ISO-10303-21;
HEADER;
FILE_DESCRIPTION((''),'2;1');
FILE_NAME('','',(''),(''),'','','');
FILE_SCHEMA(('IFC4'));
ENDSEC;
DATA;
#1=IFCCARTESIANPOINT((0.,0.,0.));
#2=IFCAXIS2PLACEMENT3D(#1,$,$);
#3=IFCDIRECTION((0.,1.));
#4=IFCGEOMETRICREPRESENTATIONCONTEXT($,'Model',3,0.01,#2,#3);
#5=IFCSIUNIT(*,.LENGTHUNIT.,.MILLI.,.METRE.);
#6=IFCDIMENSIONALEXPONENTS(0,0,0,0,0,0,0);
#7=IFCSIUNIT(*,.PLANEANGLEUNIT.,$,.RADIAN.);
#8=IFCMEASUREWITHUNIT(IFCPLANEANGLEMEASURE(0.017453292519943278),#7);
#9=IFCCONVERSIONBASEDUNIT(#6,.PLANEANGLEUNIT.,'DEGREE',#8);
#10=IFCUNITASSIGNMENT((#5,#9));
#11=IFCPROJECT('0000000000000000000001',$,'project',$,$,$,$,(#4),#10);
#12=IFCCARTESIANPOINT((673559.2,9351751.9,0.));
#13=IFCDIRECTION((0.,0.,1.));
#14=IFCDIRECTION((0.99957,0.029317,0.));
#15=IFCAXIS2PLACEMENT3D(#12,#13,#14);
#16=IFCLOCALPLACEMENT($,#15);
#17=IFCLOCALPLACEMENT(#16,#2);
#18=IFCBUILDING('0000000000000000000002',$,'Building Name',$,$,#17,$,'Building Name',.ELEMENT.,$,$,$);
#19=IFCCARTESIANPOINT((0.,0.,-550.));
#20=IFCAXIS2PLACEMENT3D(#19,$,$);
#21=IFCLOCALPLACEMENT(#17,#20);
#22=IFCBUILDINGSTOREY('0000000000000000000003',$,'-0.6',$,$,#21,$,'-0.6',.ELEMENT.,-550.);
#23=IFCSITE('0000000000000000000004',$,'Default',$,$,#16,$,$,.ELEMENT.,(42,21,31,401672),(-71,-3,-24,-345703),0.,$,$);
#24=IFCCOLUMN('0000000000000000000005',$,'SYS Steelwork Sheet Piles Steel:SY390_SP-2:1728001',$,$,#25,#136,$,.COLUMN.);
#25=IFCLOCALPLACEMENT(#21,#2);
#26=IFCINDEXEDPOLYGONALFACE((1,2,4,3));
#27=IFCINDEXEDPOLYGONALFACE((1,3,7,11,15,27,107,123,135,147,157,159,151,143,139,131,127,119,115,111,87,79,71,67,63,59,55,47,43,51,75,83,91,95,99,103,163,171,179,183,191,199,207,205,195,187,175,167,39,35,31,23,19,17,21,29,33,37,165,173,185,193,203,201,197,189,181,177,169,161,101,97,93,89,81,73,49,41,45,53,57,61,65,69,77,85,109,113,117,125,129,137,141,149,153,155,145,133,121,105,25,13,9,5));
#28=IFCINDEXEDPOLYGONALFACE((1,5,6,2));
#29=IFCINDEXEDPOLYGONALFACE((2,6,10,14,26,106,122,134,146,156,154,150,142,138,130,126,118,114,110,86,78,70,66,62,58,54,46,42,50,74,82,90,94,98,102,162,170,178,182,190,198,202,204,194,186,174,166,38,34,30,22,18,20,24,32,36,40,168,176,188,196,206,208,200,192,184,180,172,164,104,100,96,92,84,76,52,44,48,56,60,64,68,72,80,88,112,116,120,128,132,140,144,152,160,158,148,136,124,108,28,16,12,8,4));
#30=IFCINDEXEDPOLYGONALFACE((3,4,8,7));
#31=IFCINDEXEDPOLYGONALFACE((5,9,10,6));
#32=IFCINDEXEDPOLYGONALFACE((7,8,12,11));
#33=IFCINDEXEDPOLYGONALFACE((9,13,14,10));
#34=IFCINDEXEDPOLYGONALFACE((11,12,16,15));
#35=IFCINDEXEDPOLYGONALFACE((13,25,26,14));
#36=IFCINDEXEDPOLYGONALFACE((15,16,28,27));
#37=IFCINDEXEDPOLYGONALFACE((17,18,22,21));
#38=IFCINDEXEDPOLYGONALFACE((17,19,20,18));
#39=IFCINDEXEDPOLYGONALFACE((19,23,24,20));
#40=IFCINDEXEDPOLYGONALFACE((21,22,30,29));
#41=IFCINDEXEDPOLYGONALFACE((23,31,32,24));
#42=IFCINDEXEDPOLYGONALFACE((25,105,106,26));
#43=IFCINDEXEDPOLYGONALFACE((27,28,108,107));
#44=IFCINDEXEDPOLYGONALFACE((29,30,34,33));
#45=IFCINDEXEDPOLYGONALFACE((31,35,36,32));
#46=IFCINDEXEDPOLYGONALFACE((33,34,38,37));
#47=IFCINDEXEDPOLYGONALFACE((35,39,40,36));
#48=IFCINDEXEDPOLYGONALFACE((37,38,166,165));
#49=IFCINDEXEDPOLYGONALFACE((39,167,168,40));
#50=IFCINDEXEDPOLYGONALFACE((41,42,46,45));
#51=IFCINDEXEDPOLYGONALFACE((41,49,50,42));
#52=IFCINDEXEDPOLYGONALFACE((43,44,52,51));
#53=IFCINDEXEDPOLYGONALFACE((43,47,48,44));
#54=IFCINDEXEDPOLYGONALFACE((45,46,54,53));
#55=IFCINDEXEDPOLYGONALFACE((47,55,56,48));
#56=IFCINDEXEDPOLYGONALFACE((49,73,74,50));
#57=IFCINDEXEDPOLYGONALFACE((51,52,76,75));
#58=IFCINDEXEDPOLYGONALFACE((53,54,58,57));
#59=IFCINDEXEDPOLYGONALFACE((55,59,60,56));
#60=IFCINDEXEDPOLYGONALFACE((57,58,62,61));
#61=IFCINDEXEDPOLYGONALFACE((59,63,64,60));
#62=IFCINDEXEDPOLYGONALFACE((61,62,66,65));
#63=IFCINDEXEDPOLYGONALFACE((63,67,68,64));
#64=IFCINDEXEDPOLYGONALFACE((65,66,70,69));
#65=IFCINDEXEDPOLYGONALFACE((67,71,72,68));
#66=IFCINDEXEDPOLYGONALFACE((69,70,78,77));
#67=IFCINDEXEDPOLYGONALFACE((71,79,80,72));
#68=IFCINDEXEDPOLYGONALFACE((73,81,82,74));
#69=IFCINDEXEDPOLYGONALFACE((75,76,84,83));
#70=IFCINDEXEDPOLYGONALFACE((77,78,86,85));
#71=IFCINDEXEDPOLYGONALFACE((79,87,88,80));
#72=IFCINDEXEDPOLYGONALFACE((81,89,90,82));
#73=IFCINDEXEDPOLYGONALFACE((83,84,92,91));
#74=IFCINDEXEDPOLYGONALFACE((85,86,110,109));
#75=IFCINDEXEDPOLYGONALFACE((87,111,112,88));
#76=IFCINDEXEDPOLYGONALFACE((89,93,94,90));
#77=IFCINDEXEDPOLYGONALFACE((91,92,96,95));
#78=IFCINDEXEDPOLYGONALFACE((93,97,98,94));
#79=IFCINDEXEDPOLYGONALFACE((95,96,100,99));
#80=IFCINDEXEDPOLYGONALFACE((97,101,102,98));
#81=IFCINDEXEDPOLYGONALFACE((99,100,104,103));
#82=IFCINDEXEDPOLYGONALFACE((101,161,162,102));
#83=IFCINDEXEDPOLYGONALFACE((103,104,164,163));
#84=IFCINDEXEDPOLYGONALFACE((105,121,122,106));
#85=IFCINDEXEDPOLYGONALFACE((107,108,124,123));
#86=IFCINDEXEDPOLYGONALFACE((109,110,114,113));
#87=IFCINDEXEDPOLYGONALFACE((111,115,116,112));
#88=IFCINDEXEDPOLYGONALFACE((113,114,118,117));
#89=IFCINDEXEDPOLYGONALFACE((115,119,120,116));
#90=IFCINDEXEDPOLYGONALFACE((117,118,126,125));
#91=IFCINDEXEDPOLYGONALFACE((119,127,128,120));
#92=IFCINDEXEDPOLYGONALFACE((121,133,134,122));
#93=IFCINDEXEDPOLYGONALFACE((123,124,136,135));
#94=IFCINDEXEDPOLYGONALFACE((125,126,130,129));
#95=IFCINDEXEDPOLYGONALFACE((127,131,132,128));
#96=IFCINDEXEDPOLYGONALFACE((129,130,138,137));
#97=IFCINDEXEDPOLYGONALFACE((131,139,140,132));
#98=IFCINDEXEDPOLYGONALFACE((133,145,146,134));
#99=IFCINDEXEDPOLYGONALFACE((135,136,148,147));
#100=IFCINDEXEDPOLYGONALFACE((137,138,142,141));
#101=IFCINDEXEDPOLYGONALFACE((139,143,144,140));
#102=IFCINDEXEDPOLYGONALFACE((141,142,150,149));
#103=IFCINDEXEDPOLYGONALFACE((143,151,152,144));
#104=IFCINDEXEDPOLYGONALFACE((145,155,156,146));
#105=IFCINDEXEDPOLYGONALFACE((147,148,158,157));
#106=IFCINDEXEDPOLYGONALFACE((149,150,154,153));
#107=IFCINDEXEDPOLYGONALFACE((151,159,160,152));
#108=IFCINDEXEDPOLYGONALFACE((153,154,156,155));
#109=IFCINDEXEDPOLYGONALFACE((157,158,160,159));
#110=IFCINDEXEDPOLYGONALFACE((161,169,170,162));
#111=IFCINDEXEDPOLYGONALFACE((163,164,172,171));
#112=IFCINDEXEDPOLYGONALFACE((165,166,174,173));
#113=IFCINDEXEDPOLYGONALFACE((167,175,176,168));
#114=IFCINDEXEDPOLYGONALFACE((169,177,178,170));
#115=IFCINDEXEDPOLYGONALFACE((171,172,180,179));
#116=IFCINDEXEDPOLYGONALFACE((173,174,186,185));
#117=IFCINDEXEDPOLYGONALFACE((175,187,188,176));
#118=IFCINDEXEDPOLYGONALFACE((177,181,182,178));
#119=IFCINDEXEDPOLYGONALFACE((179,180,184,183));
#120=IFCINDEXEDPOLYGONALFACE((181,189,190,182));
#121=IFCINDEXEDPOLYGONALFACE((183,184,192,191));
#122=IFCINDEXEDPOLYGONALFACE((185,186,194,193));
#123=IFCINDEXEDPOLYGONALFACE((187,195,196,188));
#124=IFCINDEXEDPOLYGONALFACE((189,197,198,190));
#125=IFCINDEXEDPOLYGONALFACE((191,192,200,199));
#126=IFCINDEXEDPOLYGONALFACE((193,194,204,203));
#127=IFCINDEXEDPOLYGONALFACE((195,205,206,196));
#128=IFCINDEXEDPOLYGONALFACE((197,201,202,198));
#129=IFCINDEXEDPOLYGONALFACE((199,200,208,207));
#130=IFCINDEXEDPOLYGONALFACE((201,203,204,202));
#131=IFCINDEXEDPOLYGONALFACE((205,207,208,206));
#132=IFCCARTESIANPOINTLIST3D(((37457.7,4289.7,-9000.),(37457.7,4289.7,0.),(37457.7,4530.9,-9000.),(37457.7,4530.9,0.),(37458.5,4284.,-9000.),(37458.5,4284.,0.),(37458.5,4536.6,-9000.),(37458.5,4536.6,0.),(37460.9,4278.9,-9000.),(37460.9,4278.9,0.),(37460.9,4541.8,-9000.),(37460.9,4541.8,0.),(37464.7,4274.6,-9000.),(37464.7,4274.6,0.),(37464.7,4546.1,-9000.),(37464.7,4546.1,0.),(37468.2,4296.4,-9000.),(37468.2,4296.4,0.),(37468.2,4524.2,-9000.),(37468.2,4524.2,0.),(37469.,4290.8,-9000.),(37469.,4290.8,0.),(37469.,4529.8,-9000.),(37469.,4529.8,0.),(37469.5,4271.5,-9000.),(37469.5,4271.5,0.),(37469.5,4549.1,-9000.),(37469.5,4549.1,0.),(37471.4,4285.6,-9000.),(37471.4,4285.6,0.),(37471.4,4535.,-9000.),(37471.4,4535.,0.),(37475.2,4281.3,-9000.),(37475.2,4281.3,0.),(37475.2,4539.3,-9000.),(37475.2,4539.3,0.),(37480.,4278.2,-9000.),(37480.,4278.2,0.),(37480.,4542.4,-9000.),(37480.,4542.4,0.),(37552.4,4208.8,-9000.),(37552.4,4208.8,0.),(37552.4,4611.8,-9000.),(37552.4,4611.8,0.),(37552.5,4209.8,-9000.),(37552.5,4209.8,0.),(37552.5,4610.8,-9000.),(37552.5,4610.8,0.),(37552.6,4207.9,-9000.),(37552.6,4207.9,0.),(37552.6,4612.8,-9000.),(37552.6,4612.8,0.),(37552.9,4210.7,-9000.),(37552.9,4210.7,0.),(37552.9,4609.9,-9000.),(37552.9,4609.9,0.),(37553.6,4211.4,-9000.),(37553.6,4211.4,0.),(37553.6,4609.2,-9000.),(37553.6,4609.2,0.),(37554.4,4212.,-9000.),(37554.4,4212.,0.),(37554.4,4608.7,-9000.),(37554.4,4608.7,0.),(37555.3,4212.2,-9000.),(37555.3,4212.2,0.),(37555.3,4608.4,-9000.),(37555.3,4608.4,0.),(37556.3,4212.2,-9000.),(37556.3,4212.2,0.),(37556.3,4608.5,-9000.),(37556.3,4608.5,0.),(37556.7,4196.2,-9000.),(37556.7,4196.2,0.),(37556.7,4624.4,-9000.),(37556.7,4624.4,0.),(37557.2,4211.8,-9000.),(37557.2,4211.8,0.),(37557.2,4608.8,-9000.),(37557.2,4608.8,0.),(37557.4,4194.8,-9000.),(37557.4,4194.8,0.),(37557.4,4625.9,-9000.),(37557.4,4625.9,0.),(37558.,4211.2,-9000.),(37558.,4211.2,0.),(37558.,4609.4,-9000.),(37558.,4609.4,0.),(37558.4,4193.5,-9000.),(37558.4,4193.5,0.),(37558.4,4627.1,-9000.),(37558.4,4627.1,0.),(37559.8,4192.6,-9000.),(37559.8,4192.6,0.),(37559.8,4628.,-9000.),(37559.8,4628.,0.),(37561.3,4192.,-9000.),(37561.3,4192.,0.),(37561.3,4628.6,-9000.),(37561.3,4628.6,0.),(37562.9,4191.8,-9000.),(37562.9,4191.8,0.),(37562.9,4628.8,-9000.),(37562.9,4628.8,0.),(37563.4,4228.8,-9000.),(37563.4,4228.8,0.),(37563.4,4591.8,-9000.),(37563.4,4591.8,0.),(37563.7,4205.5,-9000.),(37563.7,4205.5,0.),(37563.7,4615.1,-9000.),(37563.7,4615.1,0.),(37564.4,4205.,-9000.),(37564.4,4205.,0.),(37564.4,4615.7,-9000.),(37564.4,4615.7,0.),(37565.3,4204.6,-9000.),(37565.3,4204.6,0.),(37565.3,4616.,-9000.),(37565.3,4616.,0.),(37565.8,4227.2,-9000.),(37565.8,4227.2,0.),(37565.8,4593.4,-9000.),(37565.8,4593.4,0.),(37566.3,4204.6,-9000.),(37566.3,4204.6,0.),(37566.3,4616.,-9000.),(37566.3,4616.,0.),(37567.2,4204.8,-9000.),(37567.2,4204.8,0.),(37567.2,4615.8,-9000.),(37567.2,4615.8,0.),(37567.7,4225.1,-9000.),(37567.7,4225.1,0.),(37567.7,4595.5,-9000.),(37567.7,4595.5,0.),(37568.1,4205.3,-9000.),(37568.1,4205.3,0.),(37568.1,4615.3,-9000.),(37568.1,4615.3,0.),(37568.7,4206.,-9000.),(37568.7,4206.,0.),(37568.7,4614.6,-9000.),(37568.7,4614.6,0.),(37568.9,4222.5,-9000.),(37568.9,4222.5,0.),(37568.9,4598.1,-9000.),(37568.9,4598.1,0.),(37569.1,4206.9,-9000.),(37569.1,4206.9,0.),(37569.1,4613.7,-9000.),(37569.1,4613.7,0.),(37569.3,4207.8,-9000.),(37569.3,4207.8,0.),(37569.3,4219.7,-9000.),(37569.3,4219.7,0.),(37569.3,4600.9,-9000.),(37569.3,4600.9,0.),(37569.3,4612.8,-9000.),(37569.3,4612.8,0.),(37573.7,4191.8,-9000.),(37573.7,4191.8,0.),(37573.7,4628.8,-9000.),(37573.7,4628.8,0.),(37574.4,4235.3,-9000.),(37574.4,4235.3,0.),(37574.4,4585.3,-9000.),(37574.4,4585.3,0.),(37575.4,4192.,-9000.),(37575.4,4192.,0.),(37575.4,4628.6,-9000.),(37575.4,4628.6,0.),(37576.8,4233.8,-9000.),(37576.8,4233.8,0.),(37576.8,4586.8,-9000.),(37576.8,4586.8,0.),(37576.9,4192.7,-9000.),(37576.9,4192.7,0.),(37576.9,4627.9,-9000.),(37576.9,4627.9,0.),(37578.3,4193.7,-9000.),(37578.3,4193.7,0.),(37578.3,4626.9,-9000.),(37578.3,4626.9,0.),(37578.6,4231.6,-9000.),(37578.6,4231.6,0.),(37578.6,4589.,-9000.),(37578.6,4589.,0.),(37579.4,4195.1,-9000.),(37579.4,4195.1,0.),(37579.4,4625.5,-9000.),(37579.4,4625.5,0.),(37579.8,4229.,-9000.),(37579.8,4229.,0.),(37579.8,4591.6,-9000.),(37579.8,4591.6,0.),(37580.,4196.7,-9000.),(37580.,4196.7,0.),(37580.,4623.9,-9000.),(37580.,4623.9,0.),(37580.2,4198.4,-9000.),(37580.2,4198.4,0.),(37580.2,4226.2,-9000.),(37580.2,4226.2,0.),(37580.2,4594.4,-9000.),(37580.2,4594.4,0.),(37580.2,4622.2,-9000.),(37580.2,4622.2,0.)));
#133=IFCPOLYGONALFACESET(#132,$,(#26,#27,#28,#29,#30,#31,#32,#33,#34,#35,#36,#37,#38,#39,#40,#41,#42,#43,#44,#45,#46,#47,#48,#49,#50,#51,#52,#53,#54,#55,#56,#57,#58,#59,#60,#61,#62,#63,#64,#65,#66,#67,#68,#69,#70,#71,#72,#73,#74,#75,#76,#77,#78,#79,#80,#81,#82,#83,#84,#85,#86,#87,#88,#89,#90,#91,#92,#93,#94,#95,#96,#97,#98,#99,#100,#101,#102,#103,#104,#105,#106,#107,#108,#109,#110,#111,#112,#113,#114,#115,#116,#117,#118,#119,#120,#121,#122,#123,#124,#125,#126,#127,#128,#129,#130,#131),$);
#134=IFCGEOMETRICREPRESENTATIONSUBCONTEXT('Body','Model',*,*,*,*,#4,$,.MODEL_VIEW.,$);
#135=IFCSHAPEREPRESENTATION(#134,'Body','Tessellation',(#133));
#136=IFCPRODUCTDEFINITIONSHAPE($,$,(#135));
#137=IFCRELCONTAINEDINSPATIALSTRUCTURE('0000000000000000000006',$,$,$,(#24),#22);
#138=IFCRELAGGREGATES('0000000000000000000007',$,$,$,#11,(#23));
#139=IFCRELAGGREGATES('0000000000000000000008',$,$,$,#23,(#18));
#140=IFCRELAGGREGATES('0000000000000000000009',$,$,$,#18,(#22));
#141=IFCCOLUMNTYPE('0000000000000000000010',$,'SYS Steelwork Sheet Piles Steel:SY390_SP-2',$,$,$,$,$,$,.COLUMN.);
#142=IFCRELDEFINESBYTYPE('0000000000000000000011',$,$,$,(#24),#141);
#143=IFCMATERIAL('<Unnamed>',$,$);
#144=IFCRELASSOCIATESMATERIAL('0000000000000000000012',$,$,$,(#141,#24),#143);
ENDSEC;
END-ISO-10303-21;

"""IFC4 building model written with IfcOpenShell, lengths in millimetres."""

from ifc_helpers import new_model, entity, si_unit, converted_unit, direction, frame, origin, place, context, subcontext, project, spatial, line, arc, indexed_curve, outline, extrude, source, transform, mapped, material, type_object, type_shapes, element, save


model = new_model("IFC4")

# Units and contexts
model_context = context("Model", 3, precision=0.01, world=origin(), true_north=direction((0.0, 1.0)))
body_context = subcontext(model_context, "Body", "Model", "MODEL_VIEW")
ifc_project = project(units=[si_unit("LENGTHUNIT", "METRE", prefix="MILLI"), converted_unit("PLANEANGLEUNIT", "DEGREE", entity("IfcPlaneAngleMeasure", 0.017453292519943278), si_unit("PLANEANGLEUNIT", "RADIAN"), dimensions=[0, 0, 0, 0, 0, 0, 0])], contexts=[model_context])

# Site, building, storey
site_placement = place(None, frame((673559.2, 9351751.9, 0.0), z_axis=(0.0, 0.0, 1.0), x_axis=(0.99957, 0.029317, 0.0)))
site = spatial("IfcSite", under=ifc_project, at=site_placement, Name="Default", CompositionType="ELEMENT", RefLatitude=(42, 21, 31, 401672), RefLongitude=(-71, -3, -24, -345703), RefElevation=0.0)
building_placement = place(site_placement, origin())
building = spatial("IfcBuilding", under=site, at=building_placement, Name="Building Name", LongName="Building Name", CompositionType="ELEMENT")
storey_placement = place(building_placement, frame((0.0, 0.0, -550.0)))
storey = spatial("IfcBuildingStorey", under=building, at=storey_placement, Name="-0.6", LongName="-0.6", CompositionType="ELEMENT", Elevation=-550.0)

# Column
ifc_material_1 = material(Name="<Unnamed>")
column_type = type_object("IfcColumnType", Name="SYS Steelwork Sheet Piles Steel:SY390_SP-2", PredefinedType="COLUMN", material=ifc_material_1)
shared_shape = source(origin(), body_context, "Body", "SweptSolid", [
    extrude(outline(indexed_curve([(-120.6, 84.7), (-131.4, 81.6), (-138.8, 73.0), (-181.5, -20.9), (-185.2, -25.2), (-190.6, -26.8), (-202.5, -26.8), (-205.5, -24.8), (-204.8, -21.2), (-199.1, -15.5), (-198.6, -11.5), (-202.5, -10.1), (-214.1, -14.2), (-217.3, -16.6), (-218.5, -20.4), (-218.5, -31.2), (-216.6, -35.8), (-211.9, -37.8), (-184.1, -37.8), (-178.7, -36.2), (-175.0, -31.9), (-132.1, 62.5), (-124.7, 71.1), (-113.9, 74.2), (113.9, 74.2), (124.7, 71.1), (132.1, 62.5), (175.0, -31.9), (178.7, -36.2), (184.1, -37.8), (211.9, -37.8), (216.6, -35.8), (218.5, -31.2), (218.5, -20.4), (217.3, -16.6), (214.1, -14.2), (202.5, -10.1), (198.6, -11.5), (199.1, -15.5), (204.8, -21.2), (205.5, -24.8), (202.5, -26.8), (190.6, -26.8), (185.2, -25.2), (181.5, -20.9), (138.8, 73.0), (131.4, 81.6), (120.6, 84.7)], segments=[arc(1, 2, 3), line(3, 4), arc(4, 5, 6), line(6, 7), arc(7, 8, 9), line(9, 10), arc(10, 11, 12), line(12, 13), arc(13, 14, 15), line(15, 16), arc(16, 17, 18), line(18, 19), arc(19, 20, 21), line(21, 22), arc(22, 23, 24), line(24, 25), arc(25, 26, 27), line(27, 28), arc(28, 29, 30), line(30, 31), arc(31, 32, 33), line(33, 34), arc(34, 35, 36), line(36, 37), arc(37, 38, 39), line(39, 40), arc(40, 41, 42), line(42, 43), arc(43, 44, 45), line(45, 46), arc(46, 47, 48), line(48, 1)], self_intersect=False)), frame((0.0, 15.3, -9550.0)), (0.0, 0.0, 1.0), 9000.0),
])
type_shapes(column_type, [shared_shape])
for number, where, z_axis, x_axis, name in (
    (1, (37557.7, 4410.3, 550.0), (0.0, 0.0, 1.0), (0.0, 1.0, 0.0), "SYS Steelwork Sheet Piles Steel:SY390_SP-2:1728001"),
):
    element("IfcColumn", number, at=place(storey_placement, frame(where, z_axis=z_axis, x_axis=x_axis)), inside=storey, type_object=column_type, material=ifc_material_1, Name=name, PredefinedType="COLUMN", context=body_context, shape_type="MappedRepresentation", body=[
        mapped(shared_shape, transform((0.0, 0.0, 0.0), scale=1.0)),
    ])

save(model, "model.ifc")
